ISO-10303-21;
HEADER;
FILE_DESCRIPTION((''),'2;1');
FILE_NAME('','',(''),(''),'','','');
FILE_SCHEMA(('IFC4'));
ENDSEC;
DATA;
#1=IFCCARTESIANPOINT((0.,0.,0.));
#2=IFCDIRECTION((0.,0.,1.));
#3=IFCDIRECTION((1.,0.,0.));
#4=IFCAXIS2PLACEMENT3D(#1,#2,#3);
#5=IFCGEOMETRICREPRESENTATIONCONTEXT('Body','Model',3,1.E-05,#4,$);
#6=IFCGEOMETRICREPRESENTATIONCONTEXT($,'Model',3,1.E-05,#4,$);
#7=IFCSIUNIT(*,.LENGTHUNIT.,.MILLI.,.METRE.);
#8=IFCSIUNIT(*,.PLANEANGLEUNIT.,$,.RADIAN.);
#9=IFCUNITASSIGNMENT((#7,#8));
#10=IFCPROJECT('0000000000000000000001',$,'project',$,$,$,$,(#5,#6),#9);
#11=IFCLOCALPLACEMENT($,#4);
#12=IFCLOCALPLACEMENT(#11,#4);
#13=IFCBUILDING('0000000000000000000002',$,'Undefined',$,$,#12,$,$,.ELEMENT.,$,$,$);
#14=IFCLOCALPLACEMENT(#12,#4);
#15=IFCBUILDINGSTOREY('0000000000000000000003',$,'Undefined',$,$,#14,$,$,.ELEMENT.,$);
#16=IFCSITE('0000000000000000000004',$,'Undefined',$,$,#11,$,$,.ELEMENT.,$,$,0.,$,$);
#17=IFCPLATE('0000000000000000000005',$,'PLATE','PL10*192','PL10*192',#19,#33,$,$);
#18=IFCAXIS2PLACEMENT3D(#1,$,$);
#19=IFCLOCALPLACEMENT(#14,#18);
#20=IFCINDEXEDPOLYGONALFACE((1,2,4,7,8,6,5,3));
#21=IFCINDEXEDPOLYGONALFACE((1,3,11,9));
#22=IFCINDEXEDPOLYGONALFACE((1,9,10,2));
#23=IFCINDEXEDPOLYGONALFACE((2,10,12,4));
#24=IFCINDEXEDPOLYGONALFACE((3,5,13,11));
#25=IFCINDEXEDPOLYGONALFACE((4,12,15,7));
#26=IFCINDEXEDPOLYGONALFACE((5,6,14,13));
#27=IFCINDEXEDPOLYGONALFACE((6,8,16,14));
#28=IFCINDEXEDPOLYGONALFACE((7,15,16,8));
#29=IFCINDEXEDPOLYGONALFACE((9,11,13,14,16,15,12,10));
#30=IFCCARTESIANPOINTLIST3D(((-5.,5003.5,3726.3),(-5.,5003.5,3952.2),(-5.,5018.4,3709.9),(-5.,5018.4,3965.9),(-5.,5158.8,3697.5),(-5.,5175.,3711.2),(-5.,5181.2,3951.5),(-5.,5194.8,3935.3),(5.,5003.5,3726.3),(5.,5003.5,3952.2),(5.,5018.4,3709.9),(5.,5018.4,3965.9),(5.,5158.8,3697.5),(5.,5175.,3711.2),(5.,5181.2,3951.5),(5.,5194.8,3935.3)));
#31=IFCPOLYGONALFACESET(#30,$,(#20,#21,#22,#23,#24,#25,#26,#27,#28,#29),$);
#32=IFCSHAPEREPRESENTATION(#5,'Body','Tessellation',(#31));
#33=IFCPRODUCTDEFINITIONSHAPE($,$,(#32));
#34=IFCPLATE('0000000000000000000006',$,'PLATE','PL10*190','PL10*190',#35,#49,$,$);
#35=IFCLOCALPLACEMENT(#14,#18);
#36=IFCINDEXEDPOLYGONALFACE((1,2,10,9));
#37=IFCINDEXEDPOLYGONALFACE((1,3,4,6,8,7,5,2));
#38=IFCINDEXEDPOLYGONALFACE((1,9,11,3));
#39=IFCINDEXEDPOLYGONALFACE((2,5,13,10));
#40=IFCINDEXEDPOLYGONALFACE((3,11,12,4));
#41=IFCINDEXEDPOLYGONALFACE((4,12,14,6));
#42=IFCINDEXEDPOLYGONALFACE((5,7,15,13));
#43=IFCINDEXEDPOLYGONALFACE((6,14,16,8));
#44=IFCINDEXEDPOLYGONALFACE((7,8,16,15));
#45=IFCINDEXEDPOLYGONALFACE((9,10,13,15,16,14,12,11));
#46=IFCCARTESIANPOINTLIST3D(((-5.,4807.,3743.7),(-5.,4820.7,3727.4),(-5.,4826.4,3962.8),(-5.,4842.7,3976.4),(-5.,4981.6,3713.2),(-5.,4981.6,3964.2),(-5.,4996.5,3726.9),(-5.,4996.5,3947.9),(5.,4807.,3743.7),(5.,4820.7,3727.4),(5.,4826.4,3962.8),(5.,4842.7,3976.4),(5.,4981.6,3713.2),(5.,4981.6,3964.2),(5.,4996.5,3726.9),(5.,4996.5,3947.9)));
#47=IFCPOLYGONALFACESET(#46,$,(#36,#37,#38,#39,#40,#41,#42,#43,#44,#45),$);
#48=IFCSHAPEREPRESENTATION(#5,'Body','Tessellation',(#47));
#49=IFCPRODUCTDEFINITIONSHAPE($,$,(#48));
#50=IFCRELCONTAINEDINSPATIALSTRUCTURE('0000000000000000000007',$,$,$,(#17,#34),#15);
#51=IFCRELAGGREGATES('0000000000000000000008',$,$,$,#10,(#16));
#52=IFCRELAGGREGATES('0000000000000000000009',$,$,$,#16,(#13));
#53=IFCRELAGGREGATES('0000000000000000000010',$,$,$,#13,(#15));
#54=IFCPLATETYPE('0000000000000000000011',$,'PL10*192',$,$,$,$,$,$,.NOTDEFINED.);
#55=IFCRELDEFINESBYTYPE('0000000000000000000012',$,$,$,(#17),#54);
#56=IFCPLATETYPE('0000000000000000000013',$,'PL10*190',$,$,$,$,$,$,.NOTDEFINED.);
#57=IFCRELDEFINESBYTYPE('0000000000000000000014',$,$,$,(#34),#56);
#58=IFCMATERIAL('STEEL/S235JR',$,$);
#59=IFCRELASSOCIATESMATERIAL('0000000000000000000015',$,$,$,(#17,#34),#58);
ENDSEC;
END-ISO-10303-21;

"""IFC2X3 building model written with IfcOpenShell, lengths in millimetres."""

from ifc_helpers import new_model, si_unit, frame, origin_with_axes, place, context, project, spatial, polyline, outline, extrude, material, type_object, element, save


model = new_model("IFC2X3")

# Units and contexts
model_context_1 = context("Model", 3, precision=1e-05, world=origin_with_axes(), identifier="Body")
model_context_2 = context("Model", 3, precision=1e-05, world=origin_with_axes())
ifc_project = project(units=[si_unit("LENGTHUNIT", "METRE", prefix="MILLI"), si_unit("PLANEANGLEUNIT", "RADIAN")], contexts=[model_context_1, model_context_2])

# Site, building, storey
site_placement = place(None, origin_with_axes())
site = spatial("IfcSite", under=ifc_project, at=site_placement, Name="Undefined", CompositionType="ELEMENT", RefElevation=0.0)
building_placement = place(site_placement, origin_with_axes())
building = spatial("IfcBuilding", under=site, at=building_placement, Name="Undefined", CompositionType="ELEMENT")
storey_placement = place(building_placement, origin_with_axes())
storey = spatial("IfcBuildingStorey", under=building, at=storey_placement, Name="Undefined", CompositionType="ELEMENT")

# Shared definitions
ifc_material = material(Name="STEEL/S235JR")

# Plates
plate_type_1 = type_object("IfcPlateType", Name="PL10*192", PredefinedType="NOTDEFINED")
plate_1_placement = place(storey_placement, frame((0.0, 5003.5, 3967.2), z_axis=(-1.0, 0.0, 0.0), x_axis=(0.0, 0.99612, -0.08801)))
element("IfcPlate", 1, at=plate_1_placement, inside=storey, type_object=plate_type_1, material=ifc_material, Name="PLATE", Description="PL10*192", ObjectType="PL10*192", context=model_context_1, shape_type="SweptSolid", body=[
    extrude(outline(polyline([(1.3, 14.9), (15.0, 0.0), (178.4, 0.0), (193.4, 15.0), (193.4, 240.0), (178.4, 255.0), (37.5, 255.0), (21.2, 240.1), (1.3, 14.9)])), frame((0.0, 0.0, -5.0), z_axis=(0.0, 0.0, 1.0), x_axis=(1.0, 0.0, 0.0)), (0.0, 0.0, 1.0), 10.0),
])
plate_type_2 = type_object("IfcPlateType", Name="PL10*190", PredefinedType="NOTDEFINED")
plate_2_placement = place(storey_placement, frame((0.0, 4996.5, 3962.9), z_axis=(1.0, 0.0, 0.0), x_axis=(0.0, -0.99612, 0.08801)))
element("IfcPlate", 2, at=plate_2_placement, inside=storey, type_object=plate_type_2, material=ifc_material, Name="PLATE", Description="PL10*190", ObjectType="PL10*190", context=model_context_1, shape_type="SweptSolid", body=[
    extrude(outline(polyline([(-1.3, 14.9), (15.0, 0.0), (154.4, 0.0), (169.4, 15.0), (169.4, 235.0), (154.4, 250.0), (-7.1, 250.0), (-20.8, 235.1), (-1.3, 14.9)])), frame((0.0, 0.0, -5.0), z_axis=(0.0, 0.0, 1.0), x_axis=(1.0, 0.0, 0.0)), (0.0, 0.0, 1.0), 10.0),
])

save(model, "model.ifc")
